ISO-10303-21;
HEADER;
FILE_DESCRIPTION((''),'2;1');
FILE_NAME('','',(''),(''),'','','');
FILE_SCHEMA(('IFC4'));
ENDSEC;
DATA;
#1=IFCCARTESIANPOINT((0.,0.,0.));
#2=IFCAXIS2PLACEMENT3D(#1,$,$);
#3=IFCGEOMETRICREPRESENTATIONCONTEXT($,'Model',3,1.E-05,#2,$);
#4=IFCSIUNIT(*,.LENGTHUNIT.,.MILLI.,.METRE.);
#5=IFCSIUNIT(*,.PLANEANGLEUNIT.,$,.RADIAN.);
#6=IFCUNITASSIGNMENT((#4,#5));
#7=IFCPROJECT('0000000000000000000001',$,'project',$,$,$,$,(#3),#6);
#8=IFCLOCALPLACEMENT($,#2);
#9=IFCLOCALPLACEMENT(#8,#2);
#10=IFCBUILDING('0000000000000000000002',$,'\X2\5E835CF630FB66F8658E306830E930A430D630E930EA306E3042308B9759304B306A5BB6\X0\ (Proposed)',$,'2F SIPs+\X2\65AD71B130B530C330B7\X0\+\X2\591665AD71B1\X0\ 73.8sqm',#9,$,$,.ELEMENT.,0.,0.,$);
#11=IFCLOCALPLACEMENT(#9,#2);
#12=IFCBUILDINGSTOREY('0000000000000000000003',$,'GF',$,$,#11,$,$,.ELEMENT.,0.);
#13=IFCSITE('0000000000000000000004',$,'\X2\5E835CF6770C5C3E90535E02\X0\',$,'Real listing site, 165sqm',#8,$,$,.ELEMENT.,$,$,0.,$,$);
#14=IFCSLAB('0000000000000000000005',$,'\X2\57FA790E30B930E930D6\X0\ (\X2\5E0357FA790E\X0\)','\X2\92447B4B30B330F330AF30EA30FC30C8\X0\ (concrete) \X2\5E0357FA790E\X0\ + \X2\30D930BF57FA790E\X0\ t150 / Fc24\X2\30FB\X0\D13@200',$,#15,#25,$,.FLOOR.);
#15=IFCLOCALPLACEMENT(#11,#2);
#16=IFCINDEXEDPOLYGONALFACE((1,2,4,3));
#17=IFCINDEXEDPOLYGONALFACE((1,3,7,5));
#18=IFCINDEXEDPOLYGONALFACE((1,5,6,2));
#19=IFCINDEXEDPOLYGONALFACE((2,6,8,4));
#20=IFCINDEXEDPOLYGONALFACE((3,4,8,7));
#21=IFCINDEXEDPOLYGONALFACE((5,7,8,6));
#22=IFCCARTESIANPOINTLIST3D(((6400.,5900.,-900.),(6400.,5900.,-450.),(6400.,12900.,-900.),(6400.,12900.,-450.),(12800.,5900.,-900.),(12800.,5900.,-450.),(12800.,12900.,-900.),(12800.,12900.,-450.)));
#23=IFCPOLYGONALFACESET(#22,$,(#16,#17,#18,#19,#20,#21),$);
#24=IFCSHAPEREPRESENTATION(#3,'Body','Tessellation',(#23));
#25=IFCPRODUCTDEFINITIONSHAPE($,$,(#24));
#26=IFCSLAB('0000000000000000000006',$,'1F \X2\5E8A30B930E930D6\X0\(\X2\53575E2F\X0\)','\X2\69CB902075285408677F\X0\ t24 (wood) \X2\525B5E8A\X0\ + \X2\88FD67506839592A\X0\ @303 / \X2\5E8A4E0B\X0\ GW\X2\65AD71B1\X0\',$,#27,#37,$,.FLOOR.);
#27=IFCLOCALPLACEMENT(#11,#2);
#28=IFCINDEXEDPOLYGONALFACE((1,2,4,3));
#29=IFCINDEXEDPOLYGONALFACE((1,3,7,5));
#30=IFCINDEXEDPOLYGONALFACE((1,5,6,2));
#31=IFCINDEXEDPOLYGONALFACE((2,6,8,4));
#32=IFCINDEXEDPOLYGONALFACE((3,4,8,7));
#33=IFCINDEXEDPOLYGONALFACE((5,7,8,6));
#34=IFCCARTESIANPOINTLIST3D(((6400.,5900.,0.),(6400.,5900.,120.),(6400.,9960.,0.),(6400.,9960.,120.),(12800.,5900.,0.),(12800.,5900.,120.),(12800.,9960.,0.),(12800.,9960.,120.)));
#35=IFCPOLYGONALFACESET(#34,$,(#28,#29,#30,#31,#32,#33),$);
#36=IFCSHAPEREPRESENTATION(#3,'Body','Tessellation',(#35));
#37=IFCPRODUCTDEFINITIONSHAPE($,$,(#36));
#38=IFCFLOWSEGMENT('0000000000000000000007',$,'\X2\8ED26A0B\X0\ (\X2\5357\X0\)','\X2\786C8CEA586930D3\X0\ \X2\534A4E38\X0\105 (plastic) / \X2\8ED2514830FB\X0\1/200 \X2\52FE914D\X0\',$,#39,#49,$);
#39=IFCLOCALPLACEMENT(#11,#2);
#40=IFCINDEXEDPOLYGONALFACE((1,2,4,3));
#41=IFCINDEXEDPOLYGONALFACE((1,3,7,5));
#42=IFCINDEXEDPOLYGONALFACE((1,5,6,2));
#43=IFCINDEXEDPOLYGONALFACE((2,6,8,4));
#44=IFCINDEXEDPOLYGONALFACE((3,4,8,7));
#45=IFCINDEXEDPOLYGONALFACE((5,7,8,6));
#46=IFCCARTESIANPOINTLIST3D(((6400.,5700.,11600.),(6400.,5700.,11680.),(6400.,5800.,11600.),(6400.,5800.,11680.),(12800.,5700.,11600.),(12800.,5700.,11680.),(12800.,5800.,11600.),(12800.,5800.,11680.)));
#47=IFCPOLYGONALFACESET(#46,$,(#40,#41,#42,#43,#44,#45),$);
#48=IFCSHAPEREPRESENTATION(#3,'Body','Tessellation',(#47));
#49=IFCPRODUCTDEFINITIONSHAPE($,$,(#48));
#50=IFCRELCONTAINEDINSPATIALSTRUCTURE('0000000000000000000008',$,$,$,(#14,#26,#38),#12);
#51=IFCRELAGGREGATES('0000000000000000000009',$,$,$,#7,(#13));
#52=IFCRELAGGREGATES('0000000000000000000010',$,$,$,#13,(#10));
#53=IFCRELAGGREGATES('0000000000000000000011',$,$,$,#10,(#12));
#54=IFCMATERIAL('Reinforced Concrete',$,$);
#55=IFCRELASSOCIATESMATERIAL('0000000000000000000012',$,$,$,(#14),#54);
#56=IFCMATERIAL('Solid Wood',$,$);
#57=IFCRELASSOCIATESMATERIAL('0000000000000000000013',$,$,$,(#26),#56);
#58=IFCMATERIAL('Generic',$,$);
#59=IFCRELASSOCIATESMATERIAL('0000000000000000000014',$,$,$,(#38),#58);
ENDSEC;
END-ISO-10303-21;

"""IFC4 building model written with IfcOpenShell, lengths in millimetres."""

from ifc_helpers import new_model, si_unit, frame, frame_2d, origin, place, context, project, spatial, rectangle, extrude, material, element, save


model = new_model("IFC4")

# Units and contexts
model_context = context("Model", 3, precision=1e-05, world=origin())
ifc_project = project(units=[si_unit("LENGTHUNIT", "METRE", prefix="MILLI"), si_unit("PLANEANGLEUNIT", "RADIAN")], contexts=[model_context])

# Site, building, storey
site_placement = place(None, origin())
site = spatial("IfcSite", under=ifc_project, at=site_placement, Name="広島県尾道市", ObjectType="Real listing site, 165sqm", CompositionType="ELEMENT", RefElevation=0.0)
building_placement = place(site_placement, origin())
building = spatial("IfcBuilding", under=site, at=building_placement, Name="広島・書斎とライブラリのある静かな家 (Proposed)", ObjectType="2F SIPs+断熱サッシ+外断熱 73.8sqm", CompositionType="ELEMENT", ElevationOfRefHeight=0.0, ElevationOfTerrain=0.0)
storey_placement = place(building_placement, origin())
storey = spatial("IfcBuildingStorey", under=building, at=storey_placement, Name="GF", CompositionType="ELEMENT", Elevation=0.0)

# Shared definitions
ifc_material_1 = material(Name="Solid Wood")

# Slabs
ifc_material_2 = material(Name="Reinforced Concrete")
slab_1_placement = place(storey_placement, frame((3200.0, 2950.0, -450.0)))
element("IfcSlab", 1, at=slab_1_placement, inside=storey, material=ifc_material_2, Name="基礎スラブ (布基礎)", Description="鉄筋コンクリート (concrete) 布基礎 + ベタ基礎 t150 / Fc24・D13@200", PredefinedType="FLOOR", context=model_context, shape_type="SweptSolid", body=[
    extrude(rectangle(XDim=6400.0, YDim=7000.0, at=frame_2d((3200.0, 3500.0))), frame((3200.0, 2950.0, -450.0)), (0.0, 0.0, 1.0), 450.0),
])
slab_2_placement = place(storey_placement, frame((3200.0, 2950.0, 0.0)))
element("IfcSlab", 2, at=slab_2_placement, inside=storey, material=ifc_material_1, Name="1F 床スラブ(南帯)", Description="構造用合板 t24 (wood) 剛床 + 製材根太 @303 / 床下 GW断熱", PredefinedType="FLOOR", context=model_context, shape_type="SweptSolid", body=[
    extrude(rectangle(XDim=6400.0, YDim=4060.0, at=frame_2d((3200.0, 2030.0))), frame((3200.0, 2950.0, 0.0)), (0.0, 0.0, 1.0), 120.0),
])

# Flow segment
ifc_material_3 = material(Name="Generic")
flow_segment_1_placement = place(storey_placement, frame((3200.0, 2850.0, 5800.0)))
element("IfcFlowSegment", 3, at=flow_segment_1_placement, inside=storey, material=ifc_material_3, Name="軒樋 (南)", Description="硬質塩ビ 半丸105 (plastic) / 軒先・1/200 勾配", context=model_context, shape_type="SweptSolid", body=[
    extrude(rectangle(XDim=6400.0, YDim=100.0, at=frame_2d((3200.0, 50.0))), frame((3200.0, 2850.0, 5800.0)), (0.0, 0.0, 1.0), 80.0),
])

save(model, "model.ifc")
